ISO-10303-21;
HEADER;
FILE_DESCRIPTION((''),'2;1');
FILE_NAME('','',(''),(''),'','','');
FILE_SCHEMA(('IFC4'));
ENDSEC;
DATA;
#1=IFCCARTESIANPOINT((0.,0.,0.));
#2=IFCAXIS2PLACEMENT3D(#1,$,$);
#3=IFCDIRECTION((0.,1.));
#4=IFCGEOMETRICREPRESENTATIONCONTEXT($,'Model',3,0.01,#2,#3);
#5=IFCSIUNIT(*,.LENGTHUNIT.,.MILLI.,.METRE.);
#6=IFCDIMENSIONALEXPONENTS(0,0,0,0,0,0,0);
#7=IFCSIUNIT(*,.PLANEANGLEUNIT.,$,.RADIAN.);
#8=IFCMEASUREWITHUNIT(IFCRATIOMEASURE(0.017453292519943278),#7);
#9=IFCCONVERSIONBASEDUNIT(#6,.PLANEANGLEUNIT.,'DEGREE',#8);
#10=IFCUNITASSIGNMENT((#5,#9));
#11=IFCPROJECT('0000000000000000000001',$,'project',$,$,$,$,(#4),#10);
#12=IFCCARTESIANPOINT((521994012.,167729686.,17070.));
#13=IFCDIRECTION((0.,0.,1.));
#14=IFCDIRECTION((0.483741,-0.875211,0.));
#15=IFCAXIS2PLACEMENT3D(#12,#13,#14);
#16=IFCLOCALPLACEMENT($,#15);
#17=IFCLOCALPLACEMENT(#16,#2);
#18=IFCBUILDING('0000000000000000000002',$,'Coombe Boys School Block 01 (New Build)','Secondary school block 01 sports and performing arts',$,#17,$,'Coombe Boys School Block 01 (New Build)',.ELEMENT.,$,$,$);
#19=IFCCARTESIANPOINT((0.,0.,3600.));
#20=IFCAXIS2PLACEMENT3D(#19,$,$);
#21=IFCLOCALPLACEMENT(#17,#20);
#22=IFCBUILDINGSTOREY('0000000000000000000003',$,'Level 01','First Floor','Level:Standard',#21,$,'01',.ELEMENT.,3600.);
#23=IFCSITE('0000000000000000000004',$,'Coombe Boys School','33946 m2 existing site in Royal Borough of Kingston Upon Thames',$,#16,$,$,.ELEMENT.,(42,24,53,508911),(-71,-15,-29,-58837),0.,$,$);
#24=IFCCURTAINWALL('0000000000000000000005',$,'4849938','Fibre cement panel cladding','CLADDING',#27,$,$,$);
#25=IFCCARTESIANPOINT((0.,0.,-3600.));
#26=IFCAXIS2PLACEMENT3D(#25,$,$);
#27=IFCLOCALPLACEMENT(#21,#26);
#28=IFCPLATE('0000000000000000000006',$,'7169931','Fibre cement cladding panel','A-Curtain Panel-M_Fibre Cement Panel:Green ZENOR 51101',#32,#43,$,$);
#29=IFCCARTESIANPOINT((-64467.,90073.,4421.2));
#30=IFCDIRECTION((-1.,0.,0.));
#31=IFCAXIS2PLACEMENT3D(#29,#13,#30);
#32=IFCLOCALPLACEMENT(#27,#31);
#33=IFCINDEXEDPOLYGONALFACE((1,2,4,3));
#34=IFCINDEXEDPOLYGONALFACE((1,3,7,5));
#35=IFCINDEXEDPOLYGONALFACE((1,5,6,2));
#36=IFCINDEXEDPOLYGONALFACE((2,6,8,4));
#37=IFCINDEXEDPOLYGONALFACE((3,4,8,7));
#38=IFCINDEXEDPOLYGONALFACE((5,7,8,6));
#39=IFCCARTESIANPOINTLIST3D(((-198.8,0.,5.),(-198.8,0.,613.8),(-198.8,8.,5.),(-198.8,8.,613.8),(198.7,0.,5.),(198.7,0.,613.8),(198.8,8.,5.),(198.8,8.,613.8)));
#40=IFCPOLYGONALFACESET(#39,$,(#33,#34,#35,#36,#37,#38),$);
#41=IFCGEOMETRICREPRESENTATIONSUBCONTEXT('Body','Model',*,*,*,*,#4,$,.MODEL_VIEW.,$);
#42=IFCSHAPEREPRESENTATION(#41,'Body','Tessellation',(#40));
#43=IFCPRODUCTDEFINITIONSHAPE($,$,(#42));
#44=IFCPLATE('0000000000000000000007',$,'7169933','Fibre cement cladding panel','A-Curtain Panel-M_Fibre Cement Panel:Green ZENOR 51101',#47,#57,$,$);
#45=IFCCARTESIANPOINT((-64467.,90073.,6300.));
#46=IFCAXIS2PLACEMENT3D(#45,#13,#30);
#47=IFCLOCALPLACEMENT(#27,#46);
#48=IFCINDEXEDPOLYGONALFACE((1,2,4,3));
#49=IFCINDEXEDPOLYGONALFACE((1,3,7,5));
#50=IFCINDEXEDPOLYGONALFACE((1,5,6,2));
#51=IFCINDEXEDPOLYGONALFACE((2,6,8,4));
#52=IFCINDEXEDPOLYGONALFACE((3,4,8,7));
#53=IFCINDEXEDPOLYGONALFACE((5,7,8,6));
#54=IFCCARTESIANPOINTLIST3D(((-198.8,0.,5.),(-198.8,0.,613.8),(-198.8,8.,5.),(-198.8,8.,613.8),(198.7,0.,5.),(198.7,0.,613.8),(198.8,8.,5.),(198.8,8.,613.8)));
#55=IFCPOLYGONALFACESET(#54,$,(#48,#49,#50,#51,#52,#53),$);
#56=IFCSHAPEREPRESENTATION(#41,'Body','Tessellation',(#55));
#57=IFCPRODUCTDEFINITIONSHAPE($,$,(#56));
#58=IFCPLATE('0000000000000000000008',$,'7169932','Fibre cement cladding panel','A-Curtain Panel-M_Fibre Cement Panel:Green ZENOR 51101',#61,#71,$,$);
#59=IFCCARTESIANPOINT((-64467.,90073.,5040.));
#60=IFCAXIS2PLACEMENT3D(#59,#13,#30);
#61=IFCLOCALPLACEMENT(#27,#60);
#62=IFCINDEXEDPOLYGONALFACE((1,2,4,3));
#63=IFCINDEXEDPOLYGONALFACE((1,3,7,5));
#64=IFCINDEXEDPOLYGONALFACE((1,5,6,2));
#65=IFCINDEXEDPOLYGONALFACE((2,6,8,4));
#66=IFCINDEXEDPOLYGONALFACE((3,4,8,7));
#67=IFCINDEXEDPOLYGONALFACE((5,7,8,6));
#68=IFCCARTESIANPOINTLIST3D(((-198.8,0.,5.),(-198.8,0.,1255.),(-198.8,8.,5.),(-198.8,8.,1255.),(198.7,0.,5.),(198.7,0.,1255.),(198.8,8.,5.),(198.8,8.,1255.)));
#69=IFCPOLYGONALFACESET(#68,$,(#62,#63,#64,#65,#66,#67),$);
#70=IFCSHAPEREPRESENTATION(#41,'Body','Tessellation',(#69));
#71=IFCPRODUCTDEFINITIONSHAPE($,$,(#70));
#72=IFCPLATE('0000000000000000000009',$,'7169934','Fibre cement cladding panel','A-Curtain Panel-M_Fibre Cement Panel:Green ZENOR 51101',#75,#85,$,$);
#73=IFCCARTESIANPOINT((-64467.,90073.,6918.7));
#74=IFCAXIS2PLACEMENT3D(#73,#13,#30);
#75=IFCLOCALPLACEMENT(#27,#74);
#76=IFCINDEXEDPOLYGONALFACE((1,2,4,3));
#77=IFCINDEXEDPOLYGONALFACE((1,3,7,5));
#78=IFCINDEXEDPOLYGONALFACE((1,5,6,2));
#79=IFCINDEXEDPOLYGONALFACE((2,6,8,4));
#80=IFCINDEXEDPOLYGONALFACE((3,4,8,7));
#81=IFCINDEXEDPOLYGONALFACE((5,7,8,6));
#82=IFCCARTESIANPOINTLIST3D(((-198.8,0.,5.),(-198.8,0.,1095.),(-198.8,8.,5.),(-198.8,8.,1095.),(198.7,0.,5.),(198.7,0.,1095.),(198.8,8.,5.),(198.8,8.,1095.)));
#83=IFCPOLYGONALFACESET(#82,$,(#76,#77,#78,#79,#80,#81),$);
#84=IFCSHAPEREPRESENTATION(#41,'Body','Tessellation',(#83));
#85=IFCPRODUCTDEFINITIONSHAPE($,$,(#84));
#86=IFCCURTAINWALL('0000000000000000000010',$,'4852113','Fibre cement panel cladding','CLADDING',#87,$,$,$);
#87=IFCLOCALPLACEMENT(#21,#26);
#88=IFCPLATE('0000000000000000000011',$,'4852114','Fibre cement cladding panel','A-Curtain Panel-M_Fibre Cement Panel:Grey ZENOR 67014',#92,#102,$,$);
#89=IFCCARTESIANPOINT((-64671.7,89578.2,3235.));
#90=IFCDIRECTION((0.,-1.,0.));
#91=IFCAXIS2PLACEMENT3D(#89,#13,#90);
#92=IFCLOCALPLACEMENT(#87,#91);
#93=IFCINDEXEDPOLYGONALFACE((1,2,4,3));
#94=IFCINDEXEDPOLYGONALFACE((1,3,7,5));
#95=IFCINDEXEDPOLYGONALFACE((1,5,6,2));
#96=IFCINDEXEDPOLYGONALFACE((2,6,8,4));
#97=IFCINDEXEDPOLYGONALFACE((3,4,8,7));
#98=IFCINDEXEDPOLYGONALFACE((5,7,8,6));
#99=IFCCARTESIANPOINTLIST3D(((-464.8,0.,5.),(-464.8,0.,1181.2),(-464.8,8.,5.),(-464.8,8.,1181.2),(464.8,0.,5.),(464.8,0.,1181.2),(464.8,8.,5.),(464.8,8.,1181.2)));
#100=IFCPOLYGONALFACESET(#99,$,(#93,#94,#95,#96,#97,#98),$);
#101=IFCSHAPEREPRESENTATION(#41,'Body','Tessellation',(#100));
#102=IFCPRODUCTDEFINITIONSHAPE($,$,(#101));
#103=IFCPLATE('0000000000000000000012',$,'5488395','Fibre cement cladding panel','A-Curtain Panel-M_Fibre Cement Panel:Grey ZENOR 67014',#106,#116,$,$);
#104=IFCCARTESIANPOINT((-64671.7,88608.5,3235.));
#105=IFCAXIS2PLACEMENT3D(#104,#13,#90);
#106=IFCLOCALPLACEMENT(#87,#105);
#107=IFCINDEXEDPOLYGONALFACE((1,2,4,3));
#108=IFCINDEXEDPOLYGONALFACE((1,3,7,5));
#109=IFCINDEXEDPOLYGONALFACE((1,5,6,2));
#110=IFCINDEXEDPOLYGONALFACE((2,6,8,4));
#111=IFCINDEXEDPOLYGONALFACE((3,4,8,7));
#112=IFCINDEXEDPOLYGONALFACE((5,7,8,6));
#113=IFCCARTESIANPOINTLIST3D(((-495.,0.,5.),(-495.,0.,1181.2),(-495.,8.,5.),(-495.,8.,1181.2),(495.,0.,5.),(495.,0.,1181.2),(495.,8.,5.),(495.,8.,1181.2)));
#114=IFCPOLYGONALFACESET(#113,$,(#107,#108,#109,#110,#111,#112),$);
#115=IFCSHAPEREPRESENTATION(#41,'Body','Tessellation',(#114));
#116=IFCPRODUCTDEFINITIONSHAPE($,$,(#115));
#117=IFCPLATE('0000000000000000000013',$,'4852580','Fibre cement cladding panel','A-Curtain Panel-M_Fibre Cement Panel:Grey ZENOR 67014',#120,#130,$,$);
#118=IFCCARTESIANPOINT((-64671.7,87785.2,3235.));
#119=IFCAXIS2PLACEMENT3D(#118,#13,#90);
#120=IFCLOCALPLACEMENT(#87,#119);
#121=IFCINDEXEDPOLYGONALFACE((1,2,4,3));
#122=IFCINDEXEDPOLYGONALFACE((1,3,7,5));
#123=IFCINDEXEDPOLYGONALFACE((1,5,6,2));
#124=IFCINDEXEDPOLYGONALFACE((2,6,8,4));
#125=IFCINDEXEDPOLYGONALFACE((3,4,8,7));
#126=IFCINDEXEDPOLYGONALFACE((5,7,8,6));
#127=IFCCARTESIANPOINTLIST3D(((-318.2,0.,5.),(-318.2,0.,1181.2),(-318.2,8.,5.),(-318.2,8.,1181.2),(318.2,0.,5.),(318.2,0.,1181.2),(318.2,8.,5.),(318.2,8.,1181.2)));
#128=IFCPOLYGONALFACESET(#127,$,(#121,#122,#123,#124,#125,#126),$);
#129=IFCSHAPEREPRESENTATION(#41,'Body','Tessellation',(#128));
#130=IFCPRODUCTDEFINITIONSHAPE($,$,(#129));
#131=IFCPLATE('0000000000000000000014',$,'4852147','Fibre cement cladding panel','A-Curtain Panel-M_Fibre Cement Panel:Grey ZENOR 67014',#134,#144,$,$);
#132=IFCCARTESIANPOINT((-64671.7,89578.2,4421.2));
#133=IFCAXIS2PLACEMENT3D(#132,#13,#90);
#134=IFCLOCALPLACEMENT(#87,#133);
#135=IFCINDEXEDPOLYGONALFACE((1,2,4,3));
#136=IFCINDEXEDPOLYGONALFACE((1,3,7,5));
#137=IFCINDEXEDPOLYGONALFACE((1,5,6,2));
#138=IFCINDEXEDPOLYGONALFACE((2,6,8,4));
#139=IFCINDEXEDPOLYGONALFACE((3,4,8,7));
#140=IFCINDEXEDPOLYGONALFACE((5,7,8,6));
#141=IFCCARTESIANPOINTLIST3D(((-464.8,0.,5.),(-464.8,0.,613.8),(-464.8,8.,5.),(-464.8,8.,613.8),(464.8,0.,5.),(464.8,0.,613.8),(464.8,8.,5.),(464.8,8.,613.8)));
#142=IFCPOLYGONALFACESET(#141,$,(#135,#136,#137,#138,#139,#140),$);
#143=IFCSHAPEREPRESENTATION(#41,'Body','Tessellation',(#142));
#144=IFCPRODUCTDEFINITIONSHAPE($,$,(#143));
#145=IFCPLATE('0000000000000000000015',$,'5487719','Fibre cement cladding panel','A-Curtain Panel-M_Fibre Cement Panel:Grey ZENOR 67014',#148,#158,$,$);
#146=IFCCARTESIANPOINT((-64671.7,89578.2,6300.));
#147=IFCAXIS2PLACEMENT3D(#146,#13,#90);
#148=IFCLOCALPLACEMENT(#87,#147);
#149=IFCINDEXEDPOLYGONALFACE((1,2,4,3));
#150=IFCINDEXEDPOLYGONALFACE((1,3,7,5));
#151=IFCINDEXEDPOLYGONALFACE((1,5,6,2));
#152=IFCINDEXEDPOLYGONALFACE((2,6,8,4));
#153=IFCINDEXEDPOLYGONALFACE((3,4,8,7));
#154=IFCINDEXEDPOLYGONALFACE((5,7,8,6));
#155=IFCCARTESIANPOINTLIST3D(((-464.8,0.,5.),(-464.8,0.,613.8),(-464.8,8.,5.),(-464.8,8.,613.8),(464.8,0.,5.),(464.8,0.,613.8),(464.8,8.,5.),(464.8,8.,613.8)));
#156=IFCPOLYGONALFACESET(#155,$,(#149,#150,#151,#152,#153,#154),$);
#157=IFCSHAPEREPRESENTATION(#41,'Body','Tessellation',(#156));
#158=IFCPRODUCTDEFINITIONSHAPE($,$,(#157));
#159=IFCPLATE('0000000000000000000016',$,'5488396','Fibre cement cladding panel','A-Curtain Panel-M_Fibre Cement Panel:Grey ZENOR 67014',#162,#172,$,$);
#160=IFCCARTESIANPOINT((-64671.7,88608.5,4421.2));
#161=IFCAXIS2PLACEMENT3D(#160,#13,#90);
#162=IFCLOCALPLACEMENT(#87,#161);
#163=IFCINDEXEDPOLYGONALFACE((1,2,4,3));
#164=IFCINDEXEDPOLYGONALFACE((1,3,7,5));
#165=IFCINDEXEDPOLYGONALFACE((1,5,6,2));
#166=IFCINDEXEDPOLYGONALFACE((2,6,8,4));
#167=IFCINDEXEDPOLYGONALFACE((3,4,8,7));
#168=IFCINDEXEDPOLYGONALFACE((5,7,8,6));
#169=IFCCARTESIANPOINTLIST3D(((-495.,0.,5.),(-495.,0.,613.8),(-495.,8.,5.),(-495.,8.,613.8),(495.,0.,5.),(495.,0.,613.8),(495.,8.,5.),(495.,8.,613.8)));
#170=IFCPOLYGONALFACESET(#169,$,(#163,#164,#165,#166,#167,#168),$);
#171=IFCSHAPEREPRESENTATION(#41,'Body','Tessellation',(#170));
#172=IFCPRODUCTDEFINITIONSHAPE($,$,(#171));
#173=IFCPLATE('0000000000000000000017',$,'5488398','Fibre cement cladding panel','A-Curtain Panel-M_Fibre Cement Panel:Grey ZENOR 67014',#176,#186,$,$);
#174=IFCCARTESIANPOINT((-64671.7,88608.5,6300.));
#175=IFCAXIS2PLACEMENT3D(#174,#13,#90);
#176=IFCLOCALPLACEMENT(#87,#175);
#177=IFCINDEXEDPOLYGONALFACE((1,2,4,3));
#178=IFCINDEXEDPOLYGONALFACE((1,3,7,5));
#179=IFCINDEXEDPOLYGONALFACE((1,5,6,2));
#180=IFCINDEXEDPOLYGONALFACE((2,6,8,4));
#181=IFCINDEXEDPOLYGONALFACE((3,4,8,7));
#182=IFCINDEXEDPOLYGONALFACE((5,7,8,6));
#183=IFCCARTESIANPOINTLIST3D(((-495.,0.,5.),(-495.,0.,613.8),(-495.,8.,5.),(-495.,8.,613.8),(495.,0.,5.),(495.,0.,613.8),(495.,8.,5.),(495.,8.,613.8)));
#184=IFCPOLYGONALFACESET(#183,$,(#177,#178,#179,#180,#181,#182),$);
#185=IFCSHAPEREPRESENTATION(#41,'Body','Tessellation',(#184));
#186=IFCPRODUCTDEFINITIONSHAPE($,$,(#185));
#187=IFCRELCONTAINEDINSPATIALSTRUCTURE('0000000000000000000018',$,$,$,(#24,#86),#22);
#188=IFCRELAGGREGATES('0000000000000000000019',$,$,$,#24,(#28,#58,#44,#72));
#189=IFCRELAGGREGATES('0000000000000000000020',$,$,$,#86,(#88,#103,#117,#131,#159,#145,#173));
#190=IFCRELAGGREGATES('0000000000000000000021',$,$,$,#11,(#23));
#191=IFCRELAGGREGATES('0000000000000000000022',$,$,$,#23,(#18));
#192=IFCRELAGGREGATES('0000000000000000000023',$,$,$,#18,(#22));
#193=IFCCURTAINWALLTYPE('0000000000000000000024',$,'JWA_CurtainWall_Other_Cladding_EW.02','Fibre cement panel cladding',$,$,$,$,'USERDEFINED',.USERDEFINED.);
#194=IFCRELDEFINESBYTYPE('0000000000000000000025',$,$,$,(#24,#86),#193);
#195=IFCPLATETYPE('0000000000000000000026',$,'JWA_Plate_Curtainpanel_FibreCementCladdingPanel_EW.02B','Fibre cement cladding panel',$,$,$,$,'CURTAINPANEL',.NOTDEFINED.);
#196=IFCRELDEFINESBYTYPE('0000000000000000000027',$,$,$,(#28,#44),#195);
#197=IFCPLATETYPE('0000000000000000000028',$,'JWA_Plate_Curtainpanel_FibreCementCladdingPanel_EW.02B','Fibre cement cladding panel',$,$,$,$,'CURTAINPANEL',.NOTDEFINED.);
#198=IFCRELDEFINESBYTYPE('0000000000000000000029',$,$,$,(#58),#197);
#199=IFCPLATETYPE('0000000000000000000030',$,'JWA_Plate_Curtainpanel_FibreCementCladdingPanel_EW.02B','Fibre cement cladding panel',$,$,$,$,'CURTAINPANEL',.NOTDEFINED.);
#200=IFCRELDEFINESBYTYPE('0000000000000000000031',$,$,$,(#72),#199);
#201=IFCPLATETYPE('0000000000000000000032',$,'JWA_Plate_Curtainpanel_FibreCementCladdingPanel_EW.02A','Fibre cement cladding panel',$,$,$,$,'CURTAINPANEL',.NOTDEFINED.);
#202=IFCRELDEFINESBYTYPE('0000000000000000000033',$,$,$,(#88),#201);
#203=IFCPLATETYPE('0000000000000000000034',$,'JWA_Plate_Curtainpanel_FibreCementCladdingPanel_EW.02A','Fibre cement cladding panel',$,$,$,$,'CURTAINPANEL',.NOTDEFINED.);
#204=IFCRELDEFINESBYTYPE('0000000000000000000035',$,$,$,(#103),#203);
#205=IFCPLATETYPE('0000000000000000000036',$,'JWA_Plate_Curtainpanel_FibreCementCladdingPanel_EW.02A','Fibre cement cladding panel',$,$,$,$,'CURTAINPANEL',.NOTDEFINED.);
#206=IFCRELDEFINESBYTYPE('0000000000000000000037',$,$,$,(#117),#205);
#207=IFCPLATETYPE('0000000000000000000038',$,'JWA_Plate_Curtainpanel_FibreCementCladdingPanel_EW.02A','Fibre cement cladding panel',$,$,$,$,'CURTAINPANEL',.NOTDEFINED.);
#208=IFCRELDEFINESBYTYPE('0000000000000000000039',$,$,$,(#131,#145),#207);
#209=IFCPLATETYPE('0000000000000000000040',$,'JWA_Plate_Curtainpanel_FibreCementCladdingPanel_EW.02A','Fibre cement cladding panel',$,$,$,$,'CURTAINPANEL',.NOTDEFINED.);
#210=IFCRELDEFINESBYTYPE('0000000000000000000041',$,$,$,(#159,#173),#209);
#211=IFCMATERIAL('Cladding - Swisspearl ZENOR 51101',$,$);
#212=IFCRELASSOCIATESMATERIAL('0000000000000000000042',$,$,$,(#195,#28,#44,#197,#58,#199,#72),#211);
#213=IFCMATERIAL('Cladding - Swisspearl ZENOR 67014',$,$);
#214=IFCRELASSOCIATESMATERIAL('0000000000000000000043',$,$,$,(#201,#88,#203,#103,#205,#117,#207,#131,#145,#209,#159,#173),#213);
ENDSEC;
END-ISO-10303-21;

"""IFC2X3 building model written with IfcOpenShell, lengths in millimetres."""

from ifc_helpers import new_model, entity, si_unit, converted_unit, direction, frame, origin, origin_2d_with_axis, place, context, subcontext, project, spatial, rectangle, extrude, source, transform, mapped, material, type_object, type_shapes, element, aggregate, save


model = new_model("IFC2X3")

# Units and contexts
model_context = context("Model", 3, precision=0.01, world=origin(), true_north=direction((0.0, 1.0)))
body_context = subcontext(model_context, "Body", "Model", "MODEL_VIEW")
ifc_project = project(units=[si_unit("LENGTHUNIT", "METRE", prefix="MILLI"), converted_unit("PLANEANGLEUNIT", "DEGREE", entity("IfcRatioMeasure", 0.017453292519943278), si_unit("PLANEANGLEUNIT", "RADIAN"), dimensions=[0, 0, 0, 0, 0, 0, 0])], contexts=[model_context])

# Site, building, storey
site_placement = place(None, frame((521994012.0, 167729686.0, 17070.0), z_axis=(0.0, 0.0, 1.0), x_axis=(0.483741, -0.875211, 0.0)))
site = spatial("IfcSite", under=ifc_project, at=site_placement, Name="Coombe Boys School", Description="33946 m2 existing site in Royal Borough of Kingston Upon Thames", CompositionType="ELEMENT", RefLatitude=(42, 24, 53, 508911), RefLongitude=(-71, -15, -29, -58837), RefElevation=0.0)
building_placement = place(site_placement, origin())
building = spatial("IfcBuilding", under=site, at=building_placement, Name="Coombe Boys School Block 01 (New Build)", Description="Secondary school block 01 sports and performing arts", LongName="Coombe Boys School Block 01 (New Build)", CompositionType="ELEMENT")
storey_placement = place(building_placement, frame((0.0, 0.0, 3600.0)))
storey = spatial("IfcBuildingStorey", under=building, at=storey_placement, Name="Level 01", Description="First Floor", ObjectType="Level:Standard", LongName="01", CompositionType="ELEMENT", Elevation=3600.0)

# Curtain walls, plates
curtain_wall_type = type_object("IfcCurtainWallType", Name="JWA_CurtainWall_Other_Cladding_EW.02", Description="Fibre cement panel cladding", ElementType="USERDEFINED", PredefinedType="USERDEFINED")
curtain_wall_1_placement = place(storey_placement, frame((0.0, 0.0, -3600.0)))
curtain_wall_1 = element("IfcCurtainWall", 1, at=curtain_wall_1_placement, inside=storey, type_object=curtain_wall_type, Name="4849938", Description="Fibre cement panel cladding", ObjectType="CLADDING")
ifc_material_1 = material(Name="Cladding - Swisspearl ZENOR 51101")
plate_type_1 = type_object("IfcPlateType", Name="JWA_Plate_Curtainpanel_FibreCementCladdingPanel_EW.02B", Description="Fibre cement cladding panel", ElementType="CURTAINPANEL", PredefinedType="NOTDEFINED", material=ifc_material_1)
shared_shape_1 = source(origin(), body_context, "Body", "SweptSolid", [
    extrude(rectangle(XDim=8.0, YDim=397.5, at=origin_2d_with_axis()), frame((0.0, 4.0, 5.0), z_axis=(0.0, 0.0, 1.0), x_axis=(0.0, 1.0, 0.0)), (0.0, 0.0, 1.0), 608.8),
])
type_shapes(plate_type_1, [shared_shape_1])
plate_1_placement = place(curtain_wall_1_placement, frame((-64467.0, 90073.0, 4421.2), z_axis=(0.0, 0.0, 1.0), x_axis=(-1.0, 0.0, 0.0)))
plate_1 = element("IfcPlate", 2, at=plate_1_placement, type_object=plate_type_1, material=ifc_material_1, Name="7169931", Description="Fibre cement cladding panel", ObjectType="A-Curtain Panel-M_Fibre Cement Panel:Green ZENOR 51101", context=body_context, shape_type="MappedRepresentation", body=[
    mapped(shared_shape_1, transform((0.0, 0.0, 0.0), scale=1.0)),
])
plate_2_placement = place(curtain_wall_1_placement, frame((-64467.0, 90073.0, 6300.0), z_axis=(0.0, 0.0, 1.0), x_axis=(-1.0, 0.0, 0.0)))
plate_2 = element("IfcPlate", 3, at=plate_2_placement, type_object=plate_type_1, material=ifc_material_1, Name="7169933", Description="Fibre cement cladding panel", ObjectType="A-Curtain Panel-M_Fibre Cement Panel:Green ZENOR 51101", context=body_context, shape_type="MappedRepresentation", body=[
    mapped(shared_shape_1, transform((0.0, 0.0, 0.0), scale=1.0)),
])
plate_type_2 = type_object("IfcPlateType", Name="JWA_Plate_Curtainpanel_FibreCementCladdingPanel_EW.02B", Description="Fibre cement cladding panel", ElementType="CURTAINPANEL", PredefinedType="NOTDEFINED", material=ifc_material_1)
shared_shape_2 = source(origin(), body_context, "Body", "SweptSolid", [
    extrude(rectangle(XDim=8.0, YDim=397.5, at=origin_2d_with_axis()), frame((0.0, 4.0, 5.0), z_axis=(0.0, 0.0, 1.0), x_axis=(0.0, 1.0, 0.0)), (0.0, 0.0, 1.0), 1250.0),
])
type_shapes(plate_type_2, [shared_shape_2])
plate_3_placement = place(curtain_wall_1_placement, frame((-64467.0, 90073.0, 5040.0), z_axis=(0.0, 0.0, 1.0), x_axis=(-1.0, 0.0, 0.0)))
plate_3 = element("IfcPlate", 4, at=plate_3_placement, type_object=plate_type_2, material=ifc_material_1, Name="7169932", Description="Fibre cement cladding panel", ObjectType="A-Curtain Panel-M_Fibre Cement Panel:Green ZENOR 51101", context=body_context, shape_type="MappedRepresentation", body=[
    mapped(shared_shape_2, transform((0.0, 0.0, 0.0), scale=1.0)),
])
plate_type_3 = type_object("IfcPlateType", Name="JWA_Plate_Curtainpanel_FibreCementCladdingPanel_EW.02B", Description="Fibre cement cladding panel", ElementType="CURTAINPANEL", PredefinedType="NOTDEFINED", material=ifc_material_1)
shared_shape_3 = source(origin(), body_context, "Body", "SweptSolid", [
    extrude(rectangle(XDim=8.0, YDim=397.5, at=origin_2d_with_axis()), frame((0.0, 4.0, 5.0), z_axis=(0.0, 0.0, 1.0), x_axis=(0.0, 1.0, 0.0)), (0.0, 0.0, 1.0), 1090.0),
])
type_shapes(plate_type_3, [shared_shape_3])
plate_4_placement = place(curtain_wall_1_placement, frame((-64467.0, 90073.0, 6918.7), z_axis=(0.0, 0.0, 1.0), x_axis=(-1.0, 0.0, 0.0)))
plate_4 = element("IfcPlate", 5, at=plate_4_placement, type_object=plate_type_3, material=ifc_material_1, Name="7169934", Description="Fibre cement cladding panel", ObjectType="A-Curtain Panel-M_Fibre Cement Panel:Green ZENOR 51101", context=body_context, shape_type="MappedRepresentation", body=[
    mapped(shared_shape_3, transform((0.0, 0.0, 0.0), scale=1.0)),
])
aggregate(curtain_wall_1, [plate_1, plate_3, plate_2, plate_4])
curtain_wall_2_placement = place(storey_placement, frame((0.0, 0.0, -3600.0)))
curtain_wall_2 = element("IfcCurtainWall", 6, at=curtain_wall_2_placement, inside=storey, type_object=curtain_wall_type, Name="4852113", Description="Fibre cement panel cladding", ObjectType="CLADDING")
ifc_material_2 = material(Name="Cladding - Swisspearl ZENOR 67014")
plate_type_4 = type_object("IfcPlateType", Name="JWA_Plate_Curtainpanel_FibreCementCladdingPanel_EW.02A", Description="Fibre cement cladding panel", ElementType="CURTAINPANEL", PredefinedType="NOTDEFINED", material=ifc_material_2)
shared_shape_4 = source(origin(), body_context, "Body", "SweptSolid", [
    extrude(rectangle(XDim=8.0, YDim=929.5, at=origin_2d_with_axis()), frame((0.0, 4.0, 5.0), z_axis=(0.0, 0.0, 1.0), x_axis=(0.0, 1.0, 0.0)), (0.0, 0.0, 1.0), 1176.2),
])
type_shapes(plate_type_4, [shared_shape_4])
plate_5_placement = place(curtain_wall_2_placement, frame((-64671.7, 89578.2, 3235.0), z_axis=(0.0, 0.0, 1.0), x_axis=(0.0, -1.0, 0.0)))
plate_5 = element("IfcPlate", 7, at=plate_5_placement, type_object=plate_type_4, material=ifc_material_2, Name="4852114", Description="Fibre cement cladding panel", ObjectType="A-Curtain Panel-M_Fibre Cement Panel:Grey ZENOR 67014", context=body_context, shape_type="MappedRepresentation", body=[
    mapped(shared_shape_4, transform((0.0, 0.0, 0.0), scale=1.0)),
])
plate_type_5 = type_object("IfcPlateType", Name="JWA_Plate_Curtainpanel_FibreCementCladdingPanel_EW.02A", Description="Fibre cement cladding panel", ElementType="CURTAINPANEL", PredefinedType="NOTDEFINED", material=ifc_material_2)
shared_shape_5 = source(origin(), body_context, "Body", "SweptSolid", [
    extrude(rectangle(XDim=8.0, YDim=990.0, at=origin_2d_with_axis()), frame((0.0, 4.0, 5.0), z_axis=(0.0, 0.0, 1.0), x_axis=(0.0, 1.0, 0.0)), (0.0, 0.0, 1.0), 1176.3),
])
type_shapes(plate_type_5, [shared_shape_5])
plate_6_placement = place(curtain_wall_2_placement, frame((-64671.7, 88608.5, 3235.0), z_axis=(0.0, 0.0, 1.0), x_axis=(0.0, -1.0, 0.0)))
plate_6 = element("IfcPlate", 8, at=plate_6_placement, type_object=plate_type_5, material=ifc_material_2, Name="5488395", Description="Fibre cement cladding panel", ObjectType="A-Curtain Panel-M_Fibre Cement Panel:Grey ZENOR 67014", context=body_context, shape_type="MappedRepresentation", body=[
    mapped(shared_shape_5, transform((0.0, 0.0, 0.0), scale=1.0)),
])
plate_type_6 = type_object("IfcPlateType", Name="JWA_Plate_Curtainpanel_FibreCementCladdingPanel_EW.02A", Description="Fibre cement cladding panel", ElementType="CURTAINPANEL", PredefinedType="NOTDEFINED", material=ifc_material_2)
shared_shape_6 = source(origin(), body_context, "Body", "SweptSolid", [
    extrude(rectangle(XDim=8.0, YDim=636.5, at=origin_2d_with_axis()), frame((0.0, 4.0, 5.0), z_axis=(0.0, 0.0, 1.0), x_axis=(0.0, 1.0, 0.0)), (0.0, 0.0, 1.0), 1176.2),
])
type_shapes(plate_type_6, [shared_shape_6])
plate_7_placement = place(curtain_wall_2_placement, frame((-64671.7, 87785.2, 3235.0), z_axis=(0.0, 0.0, 1.0), x_axis=(0.0, -1.0, 0.0)))
plate_7 = element("IfcPlate", 9, at=plate_7_placement, type_object=plate_type_6, material=ifc_material_2, Name="4852580", Description="Fibre cement cladding panel", ObjectType="A-Curtain Panel-M_Fibre Cement Panel:Grey ZENOR 67014", context=body_context, shape_type="MappedRepresentation", body=[
    mapped(shared_shape_6, transform((0.0, 0.0, 0.0), scale=1.0)),
])
plate_type_7 = type_object("IfcPlateType", Name="JWA_Plate_Curtainpanel_FibreCementCladdingPanel_EW.02A", Description="Fibre cement cladding panel", ElementType="CURTAINPANEL", PredefinedType="NOTDEFINED", material=ifc_material_2)
shared_shape_7 = source(origin(), body_context, "Body", "SweptSolid", [
    extrude(rectangle(XDim=8.0, YDim=929.5, at=origin_2d_with_axis()), frame((0.0, 4.0, 5.0), z_axis=(0.0, 0.0, 1.0), x_axis=(0.0, 1.0, 0.0)), (0.0, 0.0, 1.0), 608.8),
])
type_shapes(plate_type_7, [shared_shape_7])
plate_8_placement = place(curtain_wall_2_placement, frame((-64671.7, 89578.2, 4421.2), z_axis=(0.0, 0.0, 1.0), x_axis=(0.0, -1.0, 0.0)))
plate_8 = element("IfcPlate", 10, at=plate_8_placement, type_object=plate_type_7, material=ifc_material_2, Name="4852147", Description="Fibre cement cladding panel", ObjectType="A-Curtain Panel-M_Fibre Cement Panel:Grey ZENOR 67014", context=body_context, shape_type="MappedRepresentation", body=[
    mapped(shared_shape_7, transform((0.0, 0.0, 0.0), scale=1.0)),
])
plate_9_placement = place(curtain_wall_2_placement, frame((-64671.7, 89578.2, 6300.0), z_axis=(0.0, 0.0, 1.0), x_axis=(0.0, -1.0, 0.0)))
plate_9 = element("IfcPlate", 11, at=plate_9_placement, type_object=plate_type_7, material=ifc_material_2, Name="5487719", Description="Fibre cement cladding panel", ObjectType="A-Curtain Panel-M_Fibre Cement Panel:Grey ZENOR 67014", context=body_context, shape_type="MappedRepresentation", body=[
    mapped(shared_shape_7, transform((0.0, 0.0, 0.0), scale=1.0)),
])
plate_type_8 = type_object("IfcPlateType", Name="JWA_Plate_Curtainpanel_FibreCementCladdingPanel_EW.02A", Description="Fibre cement cladding panel", ElementType="CURTAINPANEL", PredefinedType="NOTDEFINED", material=ifc_material_2)
shared_shape_8 = source(origin(), body_context, "Body", "SweptSolid", [
    extrude(rectangle(XDim=8.0, YDim=990.0, at=origin_2d_with_axis()), frame((0.0, 4.0, 5.0), z_axis=(0.0, 0.0, 1.0), x_axis=(0.0, 1.0, 0.0)), (0.0, 0.0, 1.0), 608.8),
])
type_shapes(plate_type_8, [shared_shape_8])
plate_10_placement = place(curtain_wall_2_placement, frame((-64671.7, 88608.5, 4421.2), z_axis=(0.0, 0.0, 1.0), x_axis=(0.0, -1.0, 0.0)))
plate_10 = element("IfcPlate", 12, at=plate_10_placement, type_object=plate_type_8, material=ifc_material_2, Name="5488396", Description="Fibre cement cladding panel", ObjectType="A-Curtain Panel-M_Fibre Cement Panel:Grey ZENOR 67014", context=body_context, shape_type="MappedRepresentation", body=[
    mapped(shared_shape_8, transform((0.0, 0.0, 0.0), scale=1.0)),
])
plate_11_placement = place(curtain_wall_2_placement, frame((-64671.7, 88608.5, 6300.0), z_axis=(0.0, 0.0, 1.0), x_axis=(0.0, -1.0, 0.0)))
plate_11 = element("IfcPlate", 13, at=plate_11_placement, type_object=plate_type_8, material=ifc_material_2, Name="5488398", Description="Fibre cement cladding panel", ObjectType="A-Curtain Panel-M_Fibre Cement Panel:Grey ZENOR 67014", context=body_context, shape_type="MappedRepresentation", body=[
    mapped(shared_shape_8, transform((0.0, 0.0, 0.0), scale=1.0)),
])
aggregate(curtain_wall_2, [plate_5, plate_6, plate_7, plate_8, plate_10, plate_9, plate_11])

save(model, "model.ifc")
